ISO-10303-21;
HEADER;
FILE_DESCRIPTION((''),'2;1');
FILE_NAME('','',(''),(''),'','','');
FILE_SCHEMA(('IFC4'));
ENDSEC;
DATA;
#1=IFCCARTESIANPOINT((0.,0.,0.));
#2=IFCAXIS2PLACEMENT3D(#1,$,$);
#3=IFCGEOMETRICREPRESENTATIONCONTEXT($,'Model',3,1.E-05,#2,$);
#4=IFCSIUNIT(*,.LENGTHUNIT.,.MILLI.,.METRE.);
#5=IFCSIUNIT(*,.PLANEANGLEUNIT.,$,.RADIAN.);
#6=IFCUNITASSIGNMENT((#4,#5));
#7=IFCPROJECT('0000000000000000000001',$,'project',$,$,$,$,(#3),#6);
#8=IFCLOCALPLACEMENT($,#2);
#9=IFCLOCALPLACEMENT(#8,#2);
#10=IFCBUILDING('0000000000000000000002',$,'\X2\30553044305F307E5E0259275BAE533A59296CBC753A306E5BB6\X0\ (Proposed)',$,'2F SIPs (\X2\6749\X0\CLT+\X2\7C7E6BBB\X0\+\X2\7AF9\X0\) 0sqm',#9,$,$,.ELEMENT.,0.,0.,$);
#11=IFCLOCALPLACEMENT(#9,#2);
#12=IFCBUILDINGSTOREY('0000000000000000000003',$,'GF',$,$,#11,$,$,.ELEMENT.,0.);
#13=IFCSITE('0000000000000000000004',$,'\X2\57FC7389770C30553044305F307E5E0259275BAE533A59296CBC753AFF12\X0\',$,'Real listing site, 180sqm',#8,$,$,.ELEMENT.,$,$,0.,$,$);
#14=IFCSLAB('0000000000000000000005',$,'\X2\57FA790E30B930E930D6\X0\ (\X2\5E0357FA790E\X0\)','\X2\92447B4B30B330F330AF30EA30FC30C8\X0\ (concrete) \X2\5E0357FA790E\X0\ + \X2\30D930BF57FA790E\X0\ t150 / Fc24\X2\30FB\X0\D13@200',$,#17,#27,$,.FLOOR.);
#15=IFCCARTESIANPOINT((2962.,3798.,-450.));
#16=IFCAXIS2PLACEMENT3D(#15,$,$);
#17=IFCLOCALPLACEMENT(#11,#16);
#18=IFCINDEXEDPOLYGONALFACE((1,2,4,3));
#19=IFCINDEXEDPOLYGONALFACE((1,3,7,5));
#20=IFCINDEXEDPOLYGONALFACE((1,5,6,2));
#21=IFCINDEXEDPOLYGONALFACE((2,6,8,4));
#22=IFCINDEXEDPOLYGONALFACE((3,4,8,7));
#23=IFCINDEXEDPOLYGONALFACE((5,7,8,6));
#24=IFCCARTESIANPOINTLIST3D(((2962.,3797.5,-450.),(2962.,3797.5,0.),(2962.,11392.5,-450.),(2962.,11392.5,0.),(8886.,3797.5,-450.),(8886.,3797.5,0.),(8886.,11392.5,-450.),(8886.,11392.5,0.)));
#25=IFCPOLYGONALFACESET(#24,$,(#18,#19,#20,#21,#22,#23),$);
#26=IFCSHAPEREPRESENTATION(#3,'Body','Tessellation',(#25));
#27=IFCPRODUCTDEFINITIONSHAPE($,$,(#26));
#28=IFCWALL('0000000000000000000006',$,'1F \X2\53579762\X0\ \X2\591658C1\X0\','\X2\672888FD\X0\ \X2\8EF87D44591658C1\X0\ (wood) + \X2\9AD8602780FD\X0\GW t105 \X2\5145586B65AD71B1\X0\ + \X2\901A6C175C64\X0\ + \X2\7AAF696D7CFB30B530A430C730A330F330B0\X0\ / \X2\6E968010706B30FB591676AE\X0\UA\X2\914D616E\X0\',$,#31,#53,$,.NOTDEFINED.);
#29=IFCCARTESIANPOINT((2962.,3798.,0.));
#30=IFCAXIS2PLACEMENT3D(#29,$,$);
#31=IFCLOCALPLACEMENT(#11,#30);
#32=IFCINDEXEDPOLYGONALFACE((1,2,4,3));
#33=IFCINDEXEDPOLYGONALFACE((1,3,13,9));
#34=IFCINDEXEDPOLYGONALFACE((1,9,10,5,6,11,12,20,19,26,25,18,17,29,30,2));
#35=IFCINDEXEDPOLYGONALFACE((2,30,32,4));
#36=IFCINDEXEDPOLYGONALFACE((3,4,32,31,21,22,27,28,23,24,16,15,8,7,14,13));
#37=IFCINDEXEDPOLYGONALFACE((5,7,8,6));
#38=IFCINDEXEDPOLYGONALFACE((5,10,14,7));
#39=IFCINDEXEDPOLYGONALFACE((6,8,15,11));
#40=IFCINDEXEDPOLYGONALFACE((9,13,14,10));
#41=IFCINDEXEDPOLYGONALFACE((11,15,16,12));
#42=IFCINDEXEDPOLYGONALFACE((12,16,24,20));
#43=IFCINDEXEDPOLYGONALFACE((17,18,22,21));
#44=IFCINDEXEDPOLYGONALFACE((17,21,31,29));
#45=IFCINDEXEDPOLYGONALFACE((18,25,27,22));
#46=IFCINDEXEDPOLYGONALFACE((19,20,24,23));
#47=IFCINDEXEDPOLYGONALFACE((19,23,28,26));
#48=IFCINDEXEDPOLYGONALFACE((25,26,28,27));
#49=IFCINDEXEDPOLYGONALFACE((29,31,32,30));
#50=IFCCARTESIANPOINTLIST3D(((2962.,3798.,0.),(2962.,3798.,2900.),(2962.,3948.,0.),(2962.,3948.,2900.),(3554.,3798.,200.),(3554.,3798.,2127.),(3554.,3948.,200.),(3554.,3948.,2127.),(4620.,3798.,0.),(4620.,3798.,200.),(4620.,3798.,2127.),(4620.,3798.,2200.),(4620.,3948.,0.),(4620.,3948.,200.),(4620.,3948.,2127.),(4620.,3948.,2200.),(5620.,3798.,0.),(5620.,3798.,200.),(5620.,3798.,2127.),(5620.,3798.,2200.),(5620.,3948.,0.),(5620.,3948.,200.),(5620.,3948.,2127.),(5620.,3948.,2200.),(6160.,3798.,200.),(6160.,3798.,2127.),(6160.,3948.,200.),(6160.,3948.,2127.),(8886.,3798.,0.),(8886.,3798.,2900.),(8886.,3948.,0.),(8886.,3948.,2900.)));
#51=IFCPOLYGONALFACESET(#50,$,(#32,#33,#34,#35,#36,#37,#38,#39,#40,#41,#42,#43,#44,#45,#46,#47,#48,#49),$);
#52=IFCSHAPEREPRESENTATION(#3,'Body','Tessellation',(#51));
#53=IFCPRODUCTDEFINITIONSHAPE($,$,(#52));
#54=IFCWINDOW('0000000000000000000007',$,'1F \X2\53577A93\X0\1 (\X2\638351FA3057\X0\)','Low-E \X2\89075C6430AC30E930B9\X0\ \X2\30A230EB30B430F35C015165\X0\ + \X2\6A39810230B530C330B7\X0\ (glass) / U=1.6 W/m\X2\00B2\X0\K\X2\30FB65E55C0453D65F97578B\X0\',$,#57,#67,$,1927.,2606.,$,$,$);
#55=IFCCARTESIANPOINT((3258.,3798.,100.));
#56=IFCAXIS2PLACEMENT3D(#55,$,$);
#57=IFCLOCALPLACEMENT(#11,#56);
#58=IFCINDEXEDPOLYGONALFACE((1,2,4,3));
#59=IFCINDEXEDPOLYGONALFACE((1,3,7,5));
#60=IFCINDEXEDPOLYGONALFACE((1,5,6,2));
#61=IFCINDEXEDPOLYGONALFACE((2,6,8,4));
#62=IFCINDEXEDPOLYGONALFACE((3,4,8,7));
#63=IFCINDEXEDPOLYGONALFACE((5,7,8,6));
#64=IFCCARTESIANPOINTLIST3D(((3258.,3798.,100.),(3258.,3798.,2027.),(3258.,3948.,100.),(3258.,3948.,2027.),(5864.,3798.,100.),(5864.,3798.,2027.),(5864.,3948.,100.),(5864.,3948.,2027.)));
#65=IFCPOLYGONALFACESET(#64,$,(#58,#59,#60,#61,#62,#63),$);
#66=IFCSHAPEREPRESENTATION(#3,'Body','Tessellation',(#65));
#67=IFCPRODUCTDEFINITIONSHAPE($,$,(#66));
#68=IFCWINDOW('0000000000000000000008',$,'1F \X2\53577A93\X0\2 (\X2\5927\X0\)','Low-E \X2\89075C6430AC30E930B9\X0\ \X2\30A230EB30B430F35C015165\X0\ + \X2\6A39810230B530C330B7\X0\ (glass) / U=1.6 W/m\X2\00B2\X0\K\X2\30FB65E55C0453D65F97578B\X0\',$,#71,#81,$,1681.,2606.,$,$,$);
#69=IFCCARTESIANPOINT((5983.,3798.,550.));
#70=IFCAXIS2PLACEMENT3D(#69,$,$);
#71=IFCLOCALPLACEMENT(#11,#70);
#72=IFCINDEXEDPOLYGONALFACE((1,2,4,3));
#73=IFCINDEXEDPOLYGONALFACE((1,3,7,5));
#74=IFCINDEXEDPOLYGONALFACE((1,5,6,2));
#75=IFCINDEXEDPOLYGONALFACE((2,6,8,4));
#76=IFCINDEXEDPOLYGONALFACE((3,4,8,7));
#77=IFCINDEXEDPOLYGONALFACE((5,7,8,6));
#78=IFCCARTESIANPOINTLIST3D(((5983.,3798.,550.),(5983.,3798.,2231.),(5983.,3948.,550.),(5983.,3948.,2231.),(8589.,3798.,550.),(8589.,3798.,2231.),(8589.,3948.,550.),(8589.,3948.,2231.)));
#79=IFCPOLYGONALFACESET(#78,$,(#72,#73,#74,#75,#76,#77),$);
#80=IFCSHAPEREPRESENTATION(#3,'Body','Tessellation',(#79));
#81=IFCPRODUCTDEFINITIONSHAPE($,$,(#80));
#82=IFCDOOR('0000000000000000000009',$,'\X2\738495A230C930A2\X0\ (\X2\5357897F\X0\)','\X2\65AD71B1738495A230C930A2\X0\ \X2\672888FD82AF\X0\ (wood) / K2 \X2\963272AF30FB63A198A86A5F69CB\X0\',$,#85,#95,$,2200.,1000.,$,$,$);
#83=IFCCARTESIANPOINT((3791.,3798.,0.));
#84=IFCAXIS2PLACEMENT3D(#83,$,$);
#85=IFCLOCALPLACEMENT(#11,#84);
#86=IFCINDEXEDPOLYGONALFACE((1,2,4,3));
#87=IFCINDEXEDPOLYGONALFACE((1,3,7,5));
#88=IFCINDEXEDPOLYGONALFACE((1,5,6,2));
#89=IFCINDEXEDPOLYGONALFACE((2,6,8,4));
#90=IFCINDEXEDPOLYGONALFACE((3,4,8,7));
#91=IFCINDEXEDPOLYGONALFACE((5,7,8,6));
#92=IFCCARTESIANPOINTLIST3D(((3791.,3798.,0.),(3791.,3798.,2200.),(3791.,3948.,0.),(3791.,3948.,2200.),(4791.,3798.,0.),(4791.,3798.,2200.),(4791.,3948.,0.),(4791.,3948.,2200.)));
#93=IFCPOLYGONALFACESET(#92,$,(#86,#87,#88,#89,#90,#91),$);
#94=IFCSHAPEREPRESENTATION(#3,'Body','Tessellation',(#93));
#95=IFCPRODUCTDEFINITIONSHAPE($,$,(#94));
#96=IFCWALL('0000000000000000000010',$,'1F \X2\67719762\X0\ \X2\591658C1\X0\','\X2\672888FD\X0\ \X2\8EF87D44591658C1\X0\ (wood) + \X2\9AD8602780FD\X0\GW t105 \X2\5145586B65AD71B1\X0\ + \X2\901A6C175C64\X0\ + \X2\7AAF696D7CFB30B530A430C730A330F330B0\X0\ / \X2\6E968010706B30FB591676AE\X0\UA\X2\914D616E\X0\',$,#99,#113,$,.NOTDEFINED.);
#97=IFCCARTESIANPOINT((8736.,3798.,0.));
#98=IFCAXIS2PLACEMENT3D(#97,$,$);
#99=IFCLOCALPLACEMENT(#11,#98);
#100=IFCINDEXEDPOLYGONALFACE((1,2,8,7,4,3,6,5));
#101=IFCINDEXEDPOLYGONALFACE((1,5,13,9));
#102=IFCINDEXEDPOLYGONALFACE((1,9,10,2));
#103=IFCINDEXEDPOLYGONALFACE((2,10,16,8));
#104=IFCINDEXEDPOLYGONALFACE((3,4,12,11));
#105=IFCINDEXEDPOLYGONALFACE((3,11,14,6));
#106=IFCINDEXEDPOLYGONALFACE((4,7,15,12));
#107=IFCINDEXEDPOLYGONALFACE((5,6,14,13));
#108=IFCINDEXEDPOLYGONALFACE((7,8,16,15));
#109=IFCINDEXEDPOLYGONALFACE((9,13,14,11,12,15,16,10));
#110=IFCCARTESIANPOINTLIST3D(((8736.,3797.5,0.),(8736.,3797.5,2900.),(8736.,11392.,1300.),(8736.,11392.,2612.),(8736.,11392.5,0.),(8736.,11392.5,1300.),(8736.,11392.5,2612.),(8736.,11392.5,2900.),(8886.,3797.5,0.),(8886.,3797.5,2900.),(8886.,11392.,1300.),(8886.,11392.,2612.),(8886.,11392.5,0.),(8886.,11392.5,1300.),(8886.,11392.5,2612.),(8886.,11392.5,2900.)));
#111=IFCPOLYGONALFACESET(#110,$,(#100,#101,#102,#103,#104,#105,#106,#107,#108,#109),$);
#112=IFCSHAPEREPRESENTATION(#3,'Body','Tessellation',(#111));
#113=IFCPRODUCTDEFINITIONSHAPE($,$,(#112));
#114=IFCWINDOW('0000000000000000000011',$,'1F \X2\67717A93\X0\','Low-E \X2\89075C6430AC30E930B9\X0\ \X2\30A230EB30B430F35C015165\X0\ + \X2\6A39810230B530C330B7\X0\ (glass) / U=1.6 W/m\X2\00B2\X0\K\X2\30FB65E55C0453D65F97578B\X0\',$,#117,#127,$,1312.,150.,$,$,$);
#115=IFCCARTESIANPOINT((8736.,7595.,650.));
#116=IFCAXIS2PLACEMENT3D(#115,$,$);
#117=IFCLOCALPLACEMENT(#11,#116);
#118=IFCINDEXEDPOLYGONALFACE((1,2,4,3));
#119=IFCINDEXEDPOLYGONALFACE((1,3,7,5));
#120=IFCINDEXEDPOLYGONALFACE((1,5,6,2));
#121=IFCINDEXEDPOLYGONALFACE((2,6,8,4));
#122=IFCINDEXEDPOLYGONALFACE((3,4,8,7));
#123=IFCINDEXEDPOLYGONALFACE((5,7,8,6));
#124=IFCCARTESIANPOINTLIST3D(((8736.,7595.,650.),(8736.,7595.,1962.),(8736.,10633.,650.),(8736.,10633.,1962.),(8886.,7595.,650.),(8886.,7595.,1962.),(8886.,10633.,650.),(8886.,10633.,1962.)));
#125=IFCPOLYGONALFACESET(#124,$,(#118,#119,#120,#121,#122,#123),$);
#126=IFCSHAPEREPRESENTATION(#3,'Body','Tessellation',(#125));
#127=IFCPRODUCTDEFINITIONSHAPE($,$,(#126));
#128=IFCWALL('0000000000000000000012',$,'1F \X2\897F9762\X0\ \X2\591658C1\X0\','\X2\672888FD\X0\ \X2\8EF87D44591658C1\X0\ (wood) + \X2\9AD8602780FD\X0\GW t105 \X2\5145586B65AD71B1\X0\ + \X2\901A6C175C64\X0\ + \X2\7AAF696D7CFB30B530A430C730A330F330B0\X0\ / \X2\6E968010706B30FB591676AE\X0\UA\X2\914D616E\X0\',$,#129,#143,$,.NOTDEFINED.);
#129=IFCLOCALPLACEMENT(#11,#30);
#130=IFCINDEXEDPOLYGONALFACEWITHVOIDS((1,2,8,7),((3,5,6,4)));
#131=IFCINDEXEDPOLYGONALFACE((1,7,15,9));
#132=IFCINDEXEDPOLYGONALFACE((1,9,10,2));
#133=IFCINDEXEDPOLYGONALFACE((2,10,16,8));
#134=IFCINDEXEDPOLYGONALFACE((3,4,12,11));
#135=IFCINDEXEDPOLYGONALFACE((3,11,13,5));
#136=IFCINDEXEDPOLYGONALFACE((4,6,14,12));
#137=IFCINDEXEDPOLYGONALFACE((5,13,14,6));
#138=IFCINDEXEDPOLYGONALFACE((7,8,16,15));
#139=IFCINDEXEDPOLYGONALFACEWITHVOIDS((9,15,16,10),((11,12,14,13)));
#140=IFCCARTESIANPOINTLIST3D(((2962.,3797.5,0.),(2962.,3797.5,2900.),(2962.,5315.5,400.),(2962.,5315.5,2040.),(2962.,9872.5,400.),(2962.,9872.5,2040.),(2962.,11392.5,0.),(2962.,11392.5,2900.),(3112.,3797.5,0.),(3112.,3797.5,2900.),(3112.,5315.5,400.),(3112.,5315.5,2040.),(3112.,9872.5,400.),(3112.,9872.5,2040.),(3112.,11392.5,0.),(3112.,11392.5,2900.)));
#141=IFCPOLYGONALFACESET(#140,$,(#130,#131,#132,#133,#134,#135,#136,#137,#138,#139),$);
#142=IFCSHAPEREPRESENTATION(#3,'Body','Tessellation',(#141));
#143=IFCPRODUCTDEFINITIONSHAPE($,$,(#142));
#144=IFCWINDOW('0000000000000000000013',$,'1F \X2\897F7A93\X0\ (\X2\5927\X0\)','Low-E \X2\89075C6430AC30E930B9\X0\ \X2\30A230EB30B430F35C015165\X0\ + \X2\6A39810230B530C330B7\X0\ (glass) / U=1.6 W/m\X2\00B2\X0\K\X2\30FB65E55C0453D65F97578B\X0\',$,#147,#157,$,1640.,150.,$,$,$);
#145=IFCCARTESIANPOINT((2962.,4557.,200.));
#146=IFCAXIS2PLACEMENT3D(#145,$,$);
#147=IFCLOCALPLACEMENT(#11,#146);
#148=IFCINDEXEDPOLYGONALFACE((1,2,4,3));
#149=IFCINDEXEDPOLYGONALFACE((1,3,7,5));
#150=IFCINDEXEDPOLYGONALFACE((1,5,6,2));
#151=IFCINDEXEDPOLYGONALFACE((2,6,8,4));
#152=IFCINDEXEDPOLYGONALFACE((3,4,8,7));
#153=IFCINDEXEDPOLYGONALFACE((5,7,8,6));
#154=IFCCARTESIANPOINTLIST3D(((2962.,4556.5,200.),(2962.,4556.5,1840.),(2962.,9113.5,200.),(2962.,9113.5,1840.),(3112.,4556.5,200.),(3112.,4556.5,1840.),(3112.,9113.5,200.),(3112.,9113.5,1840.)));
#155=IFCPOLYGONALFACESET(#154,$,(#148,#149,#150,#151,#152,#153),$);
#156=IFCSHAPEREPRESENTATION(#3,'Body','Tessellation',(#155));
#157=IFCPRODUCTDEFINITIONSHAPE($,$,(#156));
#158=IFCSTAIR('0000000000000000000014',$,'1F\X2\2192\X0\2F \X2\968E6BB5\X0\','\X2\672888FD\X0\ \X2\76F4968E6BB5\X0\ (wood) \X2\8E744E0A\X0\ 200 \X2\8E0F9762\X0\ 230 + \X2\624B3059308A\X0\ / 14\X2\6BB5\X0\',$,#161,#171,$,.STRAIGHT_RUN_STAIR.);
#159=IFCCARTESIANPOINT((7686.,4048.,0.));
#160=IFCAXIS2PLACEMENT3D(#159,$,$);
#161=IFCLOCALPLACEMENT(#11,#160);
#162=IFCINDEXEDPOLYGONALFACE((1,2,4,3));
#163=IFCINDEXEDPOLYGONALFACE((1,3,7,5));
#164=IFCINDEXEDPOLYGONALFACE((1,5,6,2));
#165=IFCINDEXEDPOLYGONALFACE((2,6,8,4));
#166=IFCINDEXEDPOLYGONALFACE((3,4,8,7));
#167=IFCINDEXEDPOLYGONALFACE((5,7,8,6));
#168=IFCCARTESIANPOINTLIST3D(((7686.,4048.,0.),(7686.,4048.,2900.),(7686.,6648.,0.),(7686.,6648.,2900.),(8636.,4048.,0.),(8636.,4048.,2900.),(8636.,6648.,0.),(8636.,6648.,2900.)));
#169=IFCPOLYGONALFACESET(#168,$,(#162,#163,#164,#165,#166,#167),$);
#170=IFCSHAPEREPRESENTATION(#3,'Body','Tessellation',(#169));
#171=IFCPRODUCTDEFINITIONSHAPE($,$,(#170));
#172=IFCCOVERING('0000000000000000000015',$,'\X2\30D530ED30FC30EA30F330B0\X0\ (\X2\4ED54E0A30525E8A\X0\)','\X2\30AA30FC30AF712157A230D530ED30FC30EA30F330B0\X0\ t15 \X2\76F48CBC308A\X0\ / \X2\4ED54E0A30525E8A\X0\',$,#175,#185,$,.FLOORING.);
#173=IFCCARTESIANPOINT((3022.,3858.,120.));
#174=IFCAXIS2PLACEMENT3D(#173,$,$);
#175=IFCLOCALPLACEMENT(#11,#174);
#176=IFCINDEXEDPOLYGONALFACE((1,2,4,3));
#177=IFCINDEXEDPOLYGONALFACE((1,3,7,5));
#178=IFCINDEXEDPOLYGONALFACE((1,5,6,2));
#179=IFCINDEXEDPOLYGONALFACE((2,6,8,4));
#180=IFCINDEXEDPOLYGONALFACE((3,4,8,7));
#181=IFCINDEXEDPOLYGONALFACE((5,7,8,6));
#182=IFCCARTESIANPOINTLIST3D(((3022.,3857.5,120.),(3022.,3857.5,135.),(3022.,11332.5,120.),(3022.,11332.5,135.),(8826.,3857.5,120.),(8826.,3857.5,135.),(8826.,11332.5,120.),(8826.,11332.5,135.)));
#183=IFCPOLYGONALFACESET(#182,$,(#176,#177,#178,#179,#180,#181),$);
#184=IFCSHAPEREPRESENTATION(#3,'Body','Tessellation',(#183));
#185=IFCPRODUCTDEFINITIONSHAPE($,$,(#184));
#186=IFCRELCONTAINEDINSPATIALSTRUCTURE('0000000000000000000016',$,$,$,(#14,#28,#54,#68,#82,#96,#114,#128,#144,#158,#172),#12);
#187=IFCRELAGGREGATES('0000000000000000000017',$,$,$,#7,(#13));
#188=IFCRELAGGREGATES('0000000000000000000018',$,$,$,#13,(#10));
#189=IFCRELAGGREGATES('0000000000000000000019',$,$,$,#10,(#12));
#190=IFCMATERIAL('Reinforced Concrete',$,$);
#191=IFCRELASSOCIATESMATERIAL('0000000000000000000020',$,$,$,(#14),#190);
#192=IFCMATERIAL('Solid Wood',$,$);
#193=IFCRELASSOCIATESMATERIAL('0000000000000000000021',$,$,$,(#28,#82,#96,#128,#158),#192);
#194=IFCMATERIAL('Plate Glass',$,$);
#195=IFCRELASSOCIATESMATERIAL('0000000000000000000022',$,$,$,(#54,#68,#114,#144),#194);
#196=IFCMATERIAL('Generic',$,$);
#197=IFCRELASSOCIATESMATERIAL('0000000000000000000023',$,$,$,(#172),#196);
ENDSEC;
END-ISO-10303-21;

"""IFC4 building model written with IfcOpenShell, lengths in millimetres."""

from ifc_helpers import new_model, si_unit, frame, frame_2d, origin, place, context, project, spatial, rectangle, extrude, material, element, fill, save


model = new_model("IFC4")

# Units and contexts
model_context = context("Model", 3, precision=1e-05, world=origin())
ifc_project = project(units=[si_unit("LENGTHUNIT", "METRE", prefix="MILLI"), si_unit("PLANEANGLEUNIT", "RADIAN")], contexts=[model_context])

# Site, building, storey
site_placement = place(None, origin())
site = spatial("IfcSite", under=ifc_project, at=site_placement, Name="埼玉県さいたま市大宮区天沼町２", ObjectType="Real listing site, 180sqm", CompositionType="ELEMENT", RefElevation=0.0)
building_placement = place(site_placement, origin())
building = spatial("IfcBuilding", under=site, at=building_placement, Name="さいたま市大宮区天沼町の家 (Proposed)", ObjectType="2F SIPs (杉CLT+籾殻+竹) 0sqm", CompositionType="ELEMENT", ElevationOfRefHeight=0.0, ElevationOfTerrain=0.0)
storey_placement = place(building_placement, origin())
storey = spatial("IfcBuildingStorey", under=building, at=storey_placement, Name="GF", CompositionType="ELEMENT", Elevation=0.0)

# Slab
ifc_material_1 = material(Name="Reinforced Concrete")
slab_1_placement = place(storey_placement, frame((2962.0, 3798.0, -450.0)))
element("IfcSlab", 1, at=slab_1_placement, inside=storey, material=ifc_material_1, Name="基礎スラブ (布基礎)", Description="鉄筋コンクリート (concrete) 布基礎 + ベタ基礎 t150 / Fc24・D13@200", PredefinedType="FLOOR", context=model_context, shape_type="SweptSolid", body=[
    extrude(rectangle(XDim=5924.0, YDim=7595.0, at=frame_2d((2962.0, 3797.0))), frame((2962.0, 3798.0, -450.0)), (0.0, 0.0, 1.0), 450.0),
])
ifc_material_2 = material(Name="Solid Wood")

# Wall, openings, windows, door
wall_1_placement = place(storey_placement, frame((2962.0, 3798.0, 0.0)))
wall_1 = element("IfcWall", 2, at=wall_1_placement, inside=storey, material=ifc_material_2, Name="1F 南面 外壁", Description="木製 軸組外壁 (wood) + 高性能GW t105 充填断熱 + 通気層 + 窯業系サイディング / 準耐火・外皮UA配慮", PredefinedType="NOTDEFINED", context=model_context, shape_type="SweptSolid", body=[
    extrude(rectangle(XDim=5924.0, YDim=150.0, at=frame_2d((2962.0, 75.0))), frame((2962.0, 3798.0, 0.0)), (0.0, 0.0, 1.0), 2900.0),
])
opening_1_placement = place(storey_placement, frame((3258.0, 3798.0, 100.0)))
opening_1 = element("IfcOpeningElement", 3, at=opening_1_placement, cuts=wall_1, PredefinedType="NOTDEFINED", context=model_context, shape_type="SweptSolid", body=[
    extrude(rectangle(XDim=2606.0, YDim=150.0, at=frame_2d((1303.0, 75.0))), frame((3258.0, 3798.0, 100.0)), (0.0, 0.0, 1.0), 1927.0),
])
opening_2_placement = place(storey_placement, frame((5983.0, 3798.0, 550.0)))
opening_2 = element("IfcOpeningElement", 4, at=opening_2_placement, cuts=wall_1, PredefinedType="NOTDEFINED", context=model_context, shape_type="SweptSolid", body=[
    extrude(rectangle(XDim=2606.0, YDim=150.0, at=frame_2d((1303.0, 75.0))), frame((5983.0, 3798.0, 550.0)), (0.0, 0.0, 1.0), 1681.0),
])
opening_3_placement = place(storey_placement, frame((3791.0, 3798.0, 0.0)))
opening_3 = element("IfcOpeningElement", 5, at=opening_3_placement, cuts=wall_1, PredefinedType="NOTDEFINED", context=model_context, shape_type="SweptSolid", body=[
    extrude(rectangle(XDim=1000.0, YDim=150.0, at=frame_2d((500.0, 75.0))), frame((3791.0, 3798.0, 0.0)), (0.0, 0.0, 1.0), 2200.0),
])
ifc_material_3 = material(Name="Plate Glass")
window_1_placement = place(storey_placement, frame((3258.0, 3798.0, 100.0)))
window_1 = element("IfcWindow", 6, at=window_1_placement, inside=storey, material=ifc_material_3, Name="1F 南窓1 (掃出し)", Description="Low-E 複層ガラス アルゴン封入 + 樹脂サッシ (glass) / U=1.6 W/m²K・日射取得型", OverallHeight=1927.0, OverallWidth=2606.0, context=model_context, shape_type="SweptSolid", body=[
    extrude(rectangle(XDim=2606.0, YDim=150.0, at=frame_2d((1303.0, 75.0))), frame((3258.0, 3798.0, 100.0)), (0.0, 0.0, 1.0), 1927.0),
])
fill(opening_1, window_1)
window_2_placement = place(storey_placement, frame((5983.0, 3798.0, 550.0)))
window_2 = element("IfcWindow", 7, at=window_2_placement, inside=storey, material=ifc_material_3, Name="1F 南窓2 (大)", Description="Low-E 複層ガラス アルゴン封入 + 樹脂サッシ (glass) / U=1.6 W/m²K・日射取得型", OverallHeight=1681.0, OverallWidth=2606.0, context=model_context, shape_type="SweptSolid", body=[
    extrude(rectangle(XDim=2606.0, YDim=150.0, at=frame_2d((1303.0, 75.0))), frame((5983.0, 3798.0, 550.0)), (0.0, 0.0, 1.0), 1681.0),
])
fill(opening_2, window_2)
door_placement = place(storey_placement, frame((3791.0, 3798.0, 0.0)))
door = element("IfcDoor", 8, at=door_placement, inside=storey, material=ifc_material_2, Name="玄関ドア (南西)", Description="断熱玄関ドア 木製芯 (wood) / K2 防犯・採風機構", OverallHeight=2200.0, OverallWidth=1000.0, context=model_context, shape_type="SweptSolid", body=[
    extrude(rectangle(XDim=1000.0, YDim=150.0, at=frame_2d((500.0, 75.0))), frame((3791.0, 3798.0, 0.0)), (0.0, 0.0, 1.0), 2200.0),
])
fill(opening_3, door)

# Walls, openings, windows
wall_2_placement = place(storey_placement, frame((8736.0, 3798.0, 0.0)))
wall_2 = element("IfcWall", 9, at=wall_2_placement, inside=storey, material=ifc_material_2, Name="1F 東面 外壁", Description="木製 軸組外壁 (wood) + 高性能GW t105 充填断熱 + 通気層 + 窯業系サイディング / 準耐火・外皮UA配慮", PredefinedType="NOTDEFINED", context=model_context, shape_type="SweptSolid", body=[
    extrude(rectangle(XDim=150.0, YDim=7595.0, at=frame_2d((75.0, 3797.0))), frame((8736.0, 3798.0, 0.0)), (0.0, 0.0, 1.0), 2900.0),
])
opening_4_placement = place(storey_placement, frame((8736.0, 7595.0, 650.0)))
opening_4 = element("IfcOpeningElement", 10, at=opening_4_placement, cuts=wall_2, PredefinedType="NOTDEFINED", context=model_context, shape_type="SweptSolid", body=[
    extrude(rectangle(XDim=150.0, YDim=3038.0, at=frame_2d((75.0, 1519.0))), frame((8736.0, 7595.0, 650.0)), (0.0, 0.0, 1.0), 1312.0),
])
window_3_placement = place(storey_placement, frame((8736.0, 7595.0, 650.0)))
window_3 = element("IfcWindow", 11, at=window_3_placement, inside=storey, material=ifc_material_3, Name="1F 東窓", Description="Low-E 複層ガラス アルゴン封入 + 樹脂サッシ (glass) / U=1.6 W/m²K・日射取得型", OverallHeight=1312.0, OverallWidth=150.0, context=model_context, shape_type="SweptSolid", body=[
    extrude(rectangle(XDim=150.0, YDim=3038.0, at=frame_2d((75.0, 1519.0))), frame((8736.0, 7595.0, 650.0)), (0.0, 0.0, 1.0), 1312.0),
])
fill(opening_4, window_3)
wall_3_placement = place(storey_placement, frame((2962.0, 3798.0, 0.0)))
wall_3 = element("IfcWall", 12, at=wall_3_placement, inside=storey, material=ifc_material_2, Name="1F 西面 外壁", Description="木製 軸組外壁 (wood) + 高性能GW t105 充填断熱 + 通気層 + 窯業系サイディング / 準耐火・外皮UA配慮", PredefinedType="NOTDEFINED", context=model_context, shape_type="SweptSolid", body=[
    extrude(rectangle(XDim=150.0, YDim=7595.0, at=frame_2d((75.0, 3797.0))), frame((2962.0, 3798.0, 0.0)), (0.0, 0.0, 1.0), 2900.0),
])
opening_5_placement = place(storey_placement, frame((2962.0, 4557.0, 200.0)))
opening_5 = element("IfcOpeningElement", 13, at=opening_5_placement, cuts=wall_3, PredefinedType="NOTDEFINED", context=model_context, shape_type="SweptSolid", body=[
    extrude(rectangle(XDim=150.0, YDim=4557.0, at=frame_2d((75.0, 2278.0))), frame((2962.0, 4557.0, 200.0)), (0.0, 0.0, 1.0), 1640.0),
])
window_4_placement = place(storey_placement, frame((2962.0, 4557.0, 200.0)))
window_4 = element("IfcWindow", 14, at=window_4_placement, inside=storey, material=ifc_material_3, Name="1F 西窓 (大)", Description="Low-E 複層ガラス アルゴン封入 + 樹脂サッシ (glass) / U=1.6 W/m²K・日射取得型", OverallHeight=1640.0, OverallWidth=150.0, context=model_context, shape_type="SweptSolid", body=[
    extrude(rectangle(XDim=150.0, YDim=4557.0, at=frame_2d((75.0, 2278.0))), frame((2962.0, 4557.0, 200.0)), (0.0, 0.0, 1.0), 1640.0),
])
fill(opening_5, window_4)

# Stair
stair_placement = place(storey_placement, frame((7686.0, 4048.0, 0.0)))
element("IfcStair", 15, at=stair_placement, inside=storey, material=ifc_material_2, Name="1F→2F 階段", Description="木製 直階段 (wood) 蹴上 200 踏面 230 + 手すり / 14段", PredefinedType="STRAIGHT_RUN_STAIR", context=model_context, shape_type="SweptSolid", body=[
    extrude(rectangle(XDim=950.0, YDim=2600.0, at=frame_2d((475.0, 1300.0))), frame((7686.0, 4048.0, 0.0)), (0.0, 0.0, 1.0), 2900.0),
])

# Covering
ifc_material_4 = material(Name="Generic")
covering_placement = place(storey_placement, frame((3022.0, 3858.0, 120.0)))
element("IfcCovering", 16, at=covering_placement, inside=storey, material=ifc_material_4, Name="フローリング (仕上げ床)", Description="オーク無垢フローリング t15 直貼り / 仕上げ床", PredefinedType="FLOORING", context=model_context, shape_type="SweptSolid", body=[
    extrude(rectangle(XDim=5804.0, YDim=7475.0, at=frame_2d((2902.0, 3737.0))), frame((3022.0, 3858.0, 120.0)), (0.0, 0.0, 1.0), 15.0),
])

save(model, "model.ifc")
